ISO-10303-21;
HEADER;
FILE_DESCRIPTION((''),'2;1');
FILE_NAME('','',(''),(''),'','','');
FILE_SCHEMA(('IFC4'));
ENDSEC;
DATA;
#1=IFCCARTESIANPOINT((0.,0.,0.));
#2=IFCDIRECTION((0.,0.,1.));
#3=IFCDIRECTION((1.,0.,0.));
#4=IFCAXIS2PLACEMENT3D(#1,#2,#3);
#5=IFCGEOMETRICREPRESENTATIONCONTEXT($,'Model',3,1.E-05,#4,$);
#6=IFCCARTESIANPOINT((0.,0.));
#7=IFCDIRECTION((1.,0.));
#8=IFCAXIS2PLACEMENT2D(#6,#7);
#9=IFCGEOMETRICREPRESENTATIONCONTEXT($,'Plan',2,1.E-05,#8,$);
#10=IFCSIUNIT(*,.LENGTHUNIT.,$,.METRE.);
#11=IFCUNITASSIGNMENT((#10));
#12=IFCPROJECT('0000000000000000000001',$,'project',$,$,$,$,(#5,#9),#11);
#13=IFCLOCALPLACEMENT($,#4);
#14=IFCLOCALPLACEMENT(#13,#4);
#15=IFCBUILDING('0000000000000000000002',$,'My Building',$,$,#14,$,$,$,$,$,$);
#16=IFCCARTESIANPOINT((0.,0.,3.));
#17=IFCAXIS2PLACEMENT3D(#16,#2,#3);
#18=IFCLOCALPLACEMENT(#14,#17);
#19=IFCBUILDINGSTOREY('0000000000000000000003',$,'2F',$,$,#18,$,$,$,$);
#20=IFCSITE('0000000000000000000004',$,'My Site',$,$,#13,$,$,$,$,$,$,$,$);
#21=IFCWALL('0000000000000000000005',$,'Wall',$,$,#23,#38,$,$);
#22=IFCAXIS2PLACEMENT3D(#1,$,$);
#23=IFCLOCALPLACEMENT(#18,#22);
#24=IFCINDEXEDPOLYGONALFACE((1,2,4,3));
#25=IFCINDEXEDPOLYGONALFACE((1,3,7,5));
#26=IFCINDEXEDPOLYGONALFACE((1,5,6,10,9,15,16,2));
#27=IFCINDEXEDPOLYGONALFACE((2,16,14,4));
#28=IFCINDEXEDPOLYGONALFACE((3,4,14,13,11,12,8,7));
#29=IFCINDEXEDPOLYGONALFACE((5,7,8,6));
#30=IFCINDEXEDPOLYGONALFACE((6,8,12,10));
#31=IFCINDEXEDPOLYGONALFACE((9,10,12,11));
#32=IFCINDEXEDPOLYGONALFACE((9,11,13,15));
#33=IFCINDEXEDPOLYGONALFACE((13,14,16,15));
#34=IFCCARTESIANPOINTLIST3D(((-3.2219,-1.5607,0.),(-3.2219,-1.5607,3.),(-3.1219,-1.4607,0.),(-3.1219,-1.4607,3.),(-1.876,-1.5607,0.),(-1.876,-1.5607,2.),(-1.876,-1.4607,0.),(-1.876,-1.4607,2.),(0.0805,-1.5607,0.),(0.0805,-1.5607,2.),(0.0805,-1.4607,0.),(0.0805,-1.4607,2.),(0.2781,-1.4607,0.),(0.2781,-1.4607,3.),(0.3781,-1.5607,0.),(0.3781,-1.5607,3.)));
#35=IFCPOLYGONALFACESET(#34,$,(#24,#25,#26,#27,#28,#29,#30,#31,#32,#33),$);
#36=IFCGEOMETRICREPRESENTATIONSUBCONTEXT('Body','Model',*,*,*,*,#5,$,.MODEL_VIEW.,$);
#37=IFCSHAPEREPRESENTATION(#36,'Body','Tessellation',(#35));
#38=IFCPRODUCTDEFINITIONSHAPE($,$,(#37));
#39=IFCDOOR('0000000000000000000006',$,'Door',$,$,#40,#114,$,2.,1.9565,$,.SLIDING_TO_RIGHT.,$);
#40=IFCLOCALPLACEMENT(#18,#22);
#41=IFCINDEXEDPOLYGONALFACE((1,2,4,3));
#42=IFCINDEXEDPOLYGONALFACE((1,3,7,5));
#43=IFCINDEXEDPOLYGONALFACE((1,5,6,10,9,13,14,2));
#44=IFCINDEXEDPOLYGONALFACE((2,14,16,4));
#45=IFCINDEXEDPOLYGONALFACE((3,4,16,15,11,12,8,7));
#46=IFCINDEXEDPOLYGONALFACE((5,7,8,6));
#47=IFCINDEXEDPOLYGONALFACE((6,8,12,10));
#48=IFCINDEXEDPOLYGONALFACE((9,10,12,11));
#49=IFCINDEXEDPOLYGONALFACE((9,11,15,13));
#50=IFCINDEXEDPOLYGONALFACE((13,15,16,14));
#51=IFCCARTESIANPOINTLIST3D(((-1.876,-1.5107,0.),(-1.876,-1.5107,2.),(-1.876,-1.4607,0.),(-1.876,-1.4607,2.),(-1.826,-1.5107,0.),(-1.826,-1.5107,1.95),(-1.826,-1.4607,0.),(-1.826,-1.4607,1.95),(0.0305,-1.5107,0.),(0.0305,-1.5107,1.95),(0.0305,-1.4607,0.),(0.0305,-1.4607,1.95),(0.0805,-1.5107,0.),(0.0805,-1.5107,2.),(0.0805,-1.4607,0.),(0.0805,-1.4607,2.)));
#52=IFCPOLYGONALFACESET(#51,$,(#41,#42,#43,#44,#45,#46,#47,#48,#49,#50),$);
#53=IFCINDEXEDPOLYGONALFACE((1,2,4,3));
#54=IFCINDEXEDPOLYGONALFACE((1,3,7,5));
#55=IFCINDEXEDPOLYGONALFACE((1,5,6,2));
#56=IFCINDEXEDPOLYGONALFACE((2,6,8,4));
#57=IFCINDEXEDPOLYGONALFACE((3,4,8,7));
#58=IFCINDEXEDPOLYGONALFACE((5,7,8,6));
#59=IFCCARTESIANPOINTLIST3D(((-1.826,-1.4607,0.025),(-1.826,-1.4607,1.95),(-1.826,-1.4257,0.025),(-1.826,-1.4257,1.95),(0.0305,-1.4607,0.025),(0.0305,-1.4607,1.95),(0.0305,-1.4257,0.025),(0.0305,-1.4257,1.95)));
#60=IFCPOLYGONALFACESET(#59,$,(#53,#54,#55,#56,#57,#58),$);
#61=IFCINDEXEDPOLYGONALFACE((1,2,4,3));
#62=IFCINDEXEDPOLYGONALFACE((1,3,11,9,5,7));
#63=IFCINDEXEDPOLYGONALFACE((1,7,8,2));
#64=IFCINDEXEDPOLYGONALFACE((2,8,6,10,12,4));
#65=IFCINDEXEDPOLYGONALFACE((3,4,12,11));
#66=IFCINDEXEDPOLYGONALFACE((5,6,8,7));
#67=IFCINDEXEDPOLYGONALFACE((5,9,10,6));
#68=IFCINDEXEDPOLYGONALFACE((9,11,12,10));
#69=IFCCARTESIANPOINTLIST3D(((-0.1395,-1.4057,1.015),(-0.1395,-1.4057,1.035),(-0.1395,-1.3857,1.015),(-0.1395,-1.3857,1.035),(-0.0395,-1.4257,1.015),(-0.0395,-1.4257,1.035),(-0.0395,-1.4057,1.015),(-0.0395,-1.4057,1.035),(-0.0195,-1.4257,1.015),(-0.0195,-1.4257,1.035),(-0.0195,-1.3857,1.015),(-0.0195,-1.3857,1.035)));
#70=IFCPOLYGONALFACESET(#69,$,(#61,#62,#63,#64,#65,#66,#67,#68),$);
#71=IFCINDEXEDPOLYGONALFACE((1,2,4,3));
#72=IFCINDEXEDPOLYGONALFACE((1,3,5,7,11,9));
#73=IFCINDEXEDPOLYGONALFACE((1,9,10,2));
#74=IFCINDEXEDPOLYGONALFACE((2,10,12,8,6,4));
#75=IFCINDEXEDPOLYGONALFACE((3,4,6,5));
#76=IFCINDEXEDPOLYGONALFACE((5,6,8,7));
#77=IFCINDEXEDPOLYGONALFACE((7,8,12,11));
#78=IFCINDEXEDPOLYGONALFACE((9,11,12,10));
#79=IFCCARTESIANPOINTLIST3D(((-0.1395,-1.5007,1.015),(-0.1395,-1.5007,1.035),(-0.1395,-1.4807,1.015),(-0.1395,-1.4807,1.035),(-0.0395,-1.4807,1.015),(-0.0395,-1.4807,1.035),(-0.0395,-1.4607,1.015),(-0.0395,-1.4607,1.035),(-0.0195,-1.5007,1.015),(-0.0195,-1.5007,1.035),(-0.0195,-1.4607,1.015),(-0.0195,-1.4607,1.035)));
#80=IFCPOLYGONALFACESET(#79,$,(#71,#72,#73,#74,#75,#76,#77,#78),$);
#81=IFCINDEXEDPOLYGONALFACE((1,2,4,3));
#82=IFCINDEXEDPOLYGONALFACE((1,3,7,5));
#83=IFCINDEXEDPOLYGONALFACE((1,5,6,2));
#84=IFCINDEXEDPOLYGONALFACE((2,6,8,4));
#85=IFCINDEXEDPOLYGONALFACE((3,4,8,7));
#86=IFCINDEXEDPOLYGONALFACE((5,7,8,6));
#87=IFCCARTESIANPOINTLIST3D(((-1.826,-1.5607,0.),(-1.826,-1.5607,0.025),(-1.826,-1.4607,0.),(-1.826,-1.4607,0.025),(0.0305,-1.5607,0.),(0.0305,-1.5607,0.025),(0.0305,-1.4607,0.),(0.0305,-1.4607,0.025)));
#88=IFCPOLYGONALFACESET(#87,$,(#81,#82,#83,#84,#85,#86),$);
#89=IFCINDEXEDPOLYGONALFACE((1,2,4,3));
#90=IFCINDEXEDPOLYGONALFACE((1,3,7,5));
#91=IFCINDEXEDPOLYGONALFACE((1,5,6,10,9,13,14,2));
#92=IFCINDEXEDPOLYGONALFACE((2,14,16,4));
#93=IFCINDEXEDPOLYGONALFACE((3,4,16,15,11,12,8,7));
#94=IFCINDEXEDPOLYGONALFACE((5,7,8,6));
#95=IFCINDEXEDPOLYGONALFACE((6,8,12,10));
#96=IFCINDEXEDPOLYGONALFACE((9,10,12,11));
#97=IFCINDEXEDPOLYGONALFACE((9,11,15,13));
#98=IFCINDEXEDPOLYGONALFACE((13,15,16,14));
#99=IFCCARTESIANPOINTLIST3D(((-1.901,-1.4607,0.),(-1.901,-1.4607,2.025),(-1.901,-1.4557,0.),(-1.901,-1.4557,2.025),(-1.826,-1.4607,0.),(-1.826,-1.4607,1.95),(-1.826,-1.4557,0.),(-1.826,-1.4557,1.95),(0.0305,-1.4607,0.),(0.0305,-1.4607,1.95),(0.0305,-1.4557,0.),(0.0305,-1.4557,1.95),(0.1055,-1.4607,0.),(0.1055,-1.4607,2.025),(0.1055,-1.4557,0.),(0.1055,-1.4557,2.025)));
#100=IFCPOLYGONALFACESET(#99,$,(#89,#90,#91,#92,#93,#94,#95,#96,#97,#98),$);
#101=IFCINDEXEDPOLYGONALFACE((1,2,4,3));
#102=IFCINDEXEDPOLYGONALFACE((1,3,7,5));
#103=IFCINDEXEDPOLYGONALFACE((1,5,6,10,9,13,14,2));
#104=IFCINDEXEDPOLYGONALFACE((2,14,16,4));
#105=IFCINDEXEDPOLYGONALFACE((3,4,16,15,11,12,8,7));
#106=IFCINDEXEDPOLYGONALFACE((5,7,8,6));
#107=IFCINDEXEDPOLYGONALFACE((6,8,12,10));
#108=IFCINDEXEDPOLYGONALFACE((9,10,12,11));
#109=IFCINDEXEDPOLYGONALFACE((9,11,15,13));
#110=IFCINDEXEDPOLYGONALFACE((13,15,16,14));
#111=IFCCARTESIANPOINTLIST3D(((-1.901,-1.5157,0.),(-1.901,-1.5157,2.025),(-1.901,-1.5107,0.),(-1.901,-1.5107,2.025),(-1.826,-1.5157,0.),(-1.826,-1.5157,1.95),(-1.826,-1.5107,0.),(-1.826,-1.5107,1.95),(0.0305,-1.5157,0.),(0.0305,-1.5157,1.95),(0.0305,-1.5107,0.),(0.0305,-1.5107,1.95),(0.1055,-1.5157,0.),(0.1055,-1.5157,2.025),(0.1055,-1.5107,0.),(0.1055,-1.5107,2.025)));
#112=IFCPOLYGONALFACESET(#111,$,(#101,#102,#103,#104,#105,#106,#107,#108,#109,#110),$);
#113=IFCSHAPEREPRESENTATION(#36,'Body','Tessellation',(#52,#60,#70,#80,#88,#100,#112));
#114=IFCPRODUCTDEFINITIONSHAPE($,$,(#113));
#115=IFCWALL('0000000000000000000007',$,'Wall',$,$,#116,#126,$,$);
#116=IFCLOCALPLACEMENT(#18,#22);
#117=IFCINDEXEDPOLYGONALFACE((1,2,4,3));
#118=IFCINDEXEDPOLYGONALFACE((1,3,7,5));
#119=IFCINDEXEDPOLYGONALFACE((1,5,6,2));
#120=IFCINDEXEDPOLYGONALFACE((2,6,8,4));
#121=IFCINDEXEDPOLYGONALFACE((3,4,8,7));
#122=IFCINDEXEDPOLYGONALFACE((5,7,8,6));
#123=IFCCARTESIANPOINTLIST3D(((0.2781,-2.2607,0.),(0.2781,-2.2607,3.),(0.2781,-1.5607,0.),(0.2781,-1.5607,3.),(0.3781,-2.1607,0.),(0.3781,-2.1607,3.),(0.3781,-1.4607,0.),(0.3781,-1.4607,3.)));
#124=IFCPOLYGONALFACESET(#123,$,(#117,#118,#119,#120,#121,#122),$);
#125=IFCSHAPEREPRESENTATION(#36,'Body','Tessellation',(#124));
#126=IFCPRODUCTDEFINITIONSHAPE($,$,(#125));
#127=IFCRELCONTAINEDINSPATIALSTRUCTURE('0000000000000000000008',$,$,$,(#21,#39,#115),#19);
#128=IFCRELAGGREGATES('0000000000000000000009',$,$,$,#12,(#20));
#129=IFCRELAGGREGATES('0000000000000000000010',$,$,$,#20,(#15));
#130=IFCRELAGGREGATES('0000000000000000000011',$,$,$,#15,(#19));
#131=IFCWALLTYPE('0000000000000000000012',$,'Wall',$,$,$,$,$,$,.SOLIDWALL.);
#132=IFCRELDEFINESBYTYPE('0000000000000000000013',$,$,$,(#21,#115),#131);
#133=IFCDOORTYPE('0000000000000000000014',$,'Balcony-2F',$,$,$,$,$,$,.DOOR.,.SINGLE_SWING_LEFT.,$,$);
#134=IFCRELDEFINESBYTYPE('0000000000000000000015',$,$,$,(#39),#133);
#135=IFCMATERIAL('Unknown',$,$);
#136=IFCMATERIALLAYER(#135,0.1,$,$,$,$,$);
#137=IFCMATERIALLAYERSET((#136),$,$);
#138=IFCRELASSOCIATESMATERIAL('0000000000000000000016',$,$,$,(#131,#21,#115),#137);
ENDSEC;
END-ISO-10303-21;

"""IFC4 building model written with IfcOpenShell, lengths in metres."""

from ifc_helpers import new_model, entity, si_unit, frame, origin_with_axes, origin_2d_with_axis, place, context, subcontext, project, spatial, line, indexed_curve, outline, extrude, shape, source, transform, mapped, material, layer, layer_set, layer_usage, type_object, type_shapes, element, fill, save


model = new_model("IFC4")

# Units and contexts
model_context = context("Model", 3, precision=1e-05, world=origin_with_axes())
plan_context = context("Plan", 2, precision=1e-05, world=origin_2d_with_axis())
body_context_1 = subcontext(model_context, "Body", "Model", "MODEL_VIEW")
body_context_2 = subcontext(plan_context, "Body", "Plan", "PLAN_VIEW")
ifc_project = project(units=[si_unit("LENGTHUNIT", "METRE")], contexts=[model_context, plan_context])

# Site, building, storey
site_placement = place(None, origin_with_axes())
site = spatial("IfcSite", under=ifc_project, at=site_placement, Name="My Site")
building_placement = place(site_placement, origin_with_axes())
building = spatial("IfcBuilding", under=site, at=building_placement, Name="My Building")
storey_placement = place(building_placement, frame((0.0, 0.0, 3.0), z_axis=(0.0, 0.0, 1.0), x_axis=(1.0, 0.0, 0.0)))
storey = spatial("IfcBuildingStorey", under=building, at=storey_placement, Name="2F")

# Shared definitions
ifc_material = material(Name="Unknown")
ifc_layer = layer(ifc_material, 0.1)
ifc_layer_set = layer_set([ifc_layer])
wall_type = type_object("IfcWallType", Name="Wall", PredefinedType="SOLIDWALL", material=ifc_layer_set)

# Wall, opening, door
ifc_layer_usage_1 = layer_usage(ifc_layer_set, "AXIS2", "POSITIVE", 0.0)
wall_1_placement = place(storey_placement, frame((-3.2219, -1.5607, 0.0), z_axis=(0.0, 0.0, 1.0), x_axis=(1.0, 0.0, 0.0)))
wall_1 = element("IfcWall", 1, at=wall_1_placement, inside=storey, type_object=wall_type, material=ifc_layer_usage_1, Name="Wall", context=body_context_1, shape_type="SweptSolid", body=[
    extrude(outline(indexed_curve([(0.0, 0.0), (0.1, 0.1), (3.5, 0.1), (3.6, 0.0)], segments=[line(1, 2, 3, 4, 1)])), origin_with_axes(), (0.0, 0.0, 1.0), 3.0),
])
shared_shape_1 = source(origin_with_axes(), body_context_1, "Body", "SweptSolid", [
    extrude(outline(indexed_curve([(0.0, 0.0), (1.9565, 0.0), (1.9565, 2.0), (0.0, 2.0)], segments=[line(1, 2, 3, 4, 1)])), frame((0.0, -0.6, 0.0), z_axis=(0.0, -1.0, 0.0), x_axis=(1.0, 0.0, 0.0)), (0.0, 0.0, -1.0), 1.2),
])
opening_1_placement = place(wall_1_placement, frame((3.3023, 0.1, 0.0), z_axis=(0.0, 0.0, 1.0), x_axis=(-1.0, 0.0, 0.0)))
opening_1 = element("IfcOpeningElement", 2, at=opening_1_placement, cuts=wall_1, PredefinedType="OPENING", context=body_context_1, shape_type="MappedRepresentation", body=[
    mapped(shared_shape_1, transform((0.0, 0.0, 0.0), x_axis=(1.0, 0.0, 0.0), y_axis=(0.0, 1.0, 0.0), z_axis=(0.0, 0.0, 1.0), scale=1.0)),
])
door_type_1 = type_object("IfcDoorType", Name="Balcony-2F", OperationType="SINGLE_SWING_LEFT", PredefinedType="DOOR")
shared_shape_2 = source(origin_with_axes(), body_context_1, "Body", "SweptSolid", [
    extrude(outline(indexed_curve([(0.0, 0.0), (0.0, 2.0), (1.9565, 2.0), (1.9565, 0.0), (1.9065, 0.0), (1.9065, 1.95), (0.05, 1.95), (0.05, 0.0)], segments=[line(1, 2, 3, 4, 5, 6, 7, 8, 1)])), frame((0.0, 0.0, 0.0), z_axis=(0.0, -1.0, 0.0), x_axis=(1.0, 0.0, 0.0)), (0.0, 0.0, -1.0), 0.05),
    extrude(outline(indexed_curve([(0.0, 0.0), (1.8565, 0.0), (1.8565, 0.035), (0.0, 0.035)], segments=[line(1, 2, 3, 4, 1)])), frame((0.05, -0.035, 0.025), z_axis=(0.0, 0.0, 1.0), x_axis=(1.0, 0.0, 0.0)), (0.0, 0.0, 1.0), 1.925),
    extrude(outline(indexed_curve([(0.0, 0.0), (0.0, -0.04), (0.12, -0.04), (0.12, -0.02), (0.02, -0.02), (0.02, 0.0)], segments=[line(1, 2, 3, 4, 5, 6, 1)])), frame((0.1, -0.035, 1.015), z_axis=(0.0, 0.0, 1.0), x_axis=(1.0, 0.0, 0.0)), (0.0, 0.0, 1.0), 0.02),
    extrude(outline(indexed_curve([(0.0, 0.0), (0.0, 0.04), (0.12, 0.04), (0.12, 0.02), (0.02, 0.02), (0.02, 0.0)], segments=[line(1, 2, 3, 4, 5, 6, 1)])), frame((0.1, 0.0, 1.015), z_axis=(0.0, 0.0, 1.0), x_axis=(1.0, 0.0, 0.0)), (0.0, 0.0, 1.0), 0.02),
    extrude(outline(indexed_curve([(0.0, 0.0), (1.8565, 0.0), (1.8565, 0.1), (0.0, 0.1)], segments=[line(1, 2, 3, 4, 1)])), frame((0.05, 0.0, 0.0), z_axis=(0.0, 0.0, 1.0), x_axis=(1.0, 0.0, 0.0)), (0.0, 0.0, 1.0), 0.025),
    extrude(outline(indexed_curve([(0.0, 0.0), (0.0, 2.025), (2.0065, 2.025), (2.0065, 0.0), (1.9315, 0.0), (1.9315, 1.95), (0.075, 1.95), (0.075, 0.0)], segments=[line(1, 2, 3, 4, 5, 6, 7, 8, 1)])), frame((-0.025, -0.005, 0.0), z_axis=(0.0, -1.0, 0.0), x_axis=(1.0, 0.0, 0.0)), (0.0, 0.0, -1.0), 0.005),
    extrude(outline(indexed_curve([(0.0, 0.0), (0.0, 2.025), (2.0065, 2.025), (2.0065, 0.0), (1.9315, 0.0), (1.9315, 1.95), (0.075, 1.95), (0.075, 0.0)], segments=[line(1, 2, 3, 4, 5, 6, 7, 8, 1)])), frame((-0.025, 0.05, 0.0), z_axis=(0.0, -1.0, 0.0), x_axis=(1.0, 0.0, 0.0)), (0.0, 0.0, -1.0), 0.005),
])
shared_shape_3 = source(origin_with_axes(), body_context_2, "Body", "Curve2D", [
    entity("IfcIndexedPolyCurve", entity("IfcCartesianPointList2D", [[0.0, 0.0], [0.05, 0.0], [0.05, 0.05], [0.0, 0.05]]), [entity("IfcLineIndex", [1, 2, 3, 4, 1])]),
    entity("IfcIndexedPolyCurve", entity("IfcCartesianPointList2D", [[1.9565, 0.0], [1.9065, 0.0], [1.9065, 0.05], [1.9565, 0.05]]), [entity("IfcLineIndex", [1, 2, 3, 4, 1])]),
    entity("IfcIndexedPolyCurve", entity("IfcCartesianPointList2D", [[2.8347, -0.035], [0.9782, -0.035], [0.9782, 0.0], [2.8347, 0.0]]), [entity("IfcLineIndex", [1, 2, 3, 4, 1])]),
])
type_shapes(door_type_1, [shared_shape_2, shared_shape_3])
door_1_placement = place(opening_1_placement, origin_with_axes())
door_1 = element("IfcDoor", 3, at=door_1_placement, inside=storey, type_object=door_type_1, Name="Door", OperationType="SLIDING_TO_RIGHT", OverallHeight=2.0, OverallWidth=1.9565, shapes=[
    shape(body_context_1, "Body", "MappedRepresentation", [mapped(shared_shape_2, transform((0.0, 0.0, 0.0), x_axis=(1.0, 0.0, 0.0), y_axis=(0.0, 1.0, 0.0), z_axis=(0.0, 0.0, 1.0), scale=1.0))]),
    shape(body_context_2, "Body", "MappedRepresentation", [mapped(shared_shape_3, transform((0.0, 0.0, 0.0), x_axis=(1.0, 0.0, 0.0), y_axis=(0.0, 1.0, 0.0), z_axis=(0.0, 0.0, 1.0), scale=1.0))]),
])
fill(opening_1, door_1)

# Wall
ifc_layer_usage_2 = layer_usage(ifc_layer_set, "AXIS2", "POSITIVE", 0.0)
wall_2_placement = place(storey_placement, frame((0.2781, -1.5607, 0.0), z_axis=(0.0, 0.0, 1.0), x_axis=(0.0, -1.0, 0.0)))
element("IfcWall", 4, at=wall_2_placement, inside=storey, type_object=wall_type, material=ifc_layer_usage_2, Name="Wall", context=body_context_1, shape_type="SweptSolid", body=[
    extrude(outline(indexed_curve([(0.0, 0.0), (-0.1, 0.1), (0.6, 0.1), (0.7, 0.0)], segments=[line(1, 2, 3, 4, 1)])), origin_with_axes(), (0.0, 0.0, 1.0), 3.0),
])

save(model, "model.ifc")
